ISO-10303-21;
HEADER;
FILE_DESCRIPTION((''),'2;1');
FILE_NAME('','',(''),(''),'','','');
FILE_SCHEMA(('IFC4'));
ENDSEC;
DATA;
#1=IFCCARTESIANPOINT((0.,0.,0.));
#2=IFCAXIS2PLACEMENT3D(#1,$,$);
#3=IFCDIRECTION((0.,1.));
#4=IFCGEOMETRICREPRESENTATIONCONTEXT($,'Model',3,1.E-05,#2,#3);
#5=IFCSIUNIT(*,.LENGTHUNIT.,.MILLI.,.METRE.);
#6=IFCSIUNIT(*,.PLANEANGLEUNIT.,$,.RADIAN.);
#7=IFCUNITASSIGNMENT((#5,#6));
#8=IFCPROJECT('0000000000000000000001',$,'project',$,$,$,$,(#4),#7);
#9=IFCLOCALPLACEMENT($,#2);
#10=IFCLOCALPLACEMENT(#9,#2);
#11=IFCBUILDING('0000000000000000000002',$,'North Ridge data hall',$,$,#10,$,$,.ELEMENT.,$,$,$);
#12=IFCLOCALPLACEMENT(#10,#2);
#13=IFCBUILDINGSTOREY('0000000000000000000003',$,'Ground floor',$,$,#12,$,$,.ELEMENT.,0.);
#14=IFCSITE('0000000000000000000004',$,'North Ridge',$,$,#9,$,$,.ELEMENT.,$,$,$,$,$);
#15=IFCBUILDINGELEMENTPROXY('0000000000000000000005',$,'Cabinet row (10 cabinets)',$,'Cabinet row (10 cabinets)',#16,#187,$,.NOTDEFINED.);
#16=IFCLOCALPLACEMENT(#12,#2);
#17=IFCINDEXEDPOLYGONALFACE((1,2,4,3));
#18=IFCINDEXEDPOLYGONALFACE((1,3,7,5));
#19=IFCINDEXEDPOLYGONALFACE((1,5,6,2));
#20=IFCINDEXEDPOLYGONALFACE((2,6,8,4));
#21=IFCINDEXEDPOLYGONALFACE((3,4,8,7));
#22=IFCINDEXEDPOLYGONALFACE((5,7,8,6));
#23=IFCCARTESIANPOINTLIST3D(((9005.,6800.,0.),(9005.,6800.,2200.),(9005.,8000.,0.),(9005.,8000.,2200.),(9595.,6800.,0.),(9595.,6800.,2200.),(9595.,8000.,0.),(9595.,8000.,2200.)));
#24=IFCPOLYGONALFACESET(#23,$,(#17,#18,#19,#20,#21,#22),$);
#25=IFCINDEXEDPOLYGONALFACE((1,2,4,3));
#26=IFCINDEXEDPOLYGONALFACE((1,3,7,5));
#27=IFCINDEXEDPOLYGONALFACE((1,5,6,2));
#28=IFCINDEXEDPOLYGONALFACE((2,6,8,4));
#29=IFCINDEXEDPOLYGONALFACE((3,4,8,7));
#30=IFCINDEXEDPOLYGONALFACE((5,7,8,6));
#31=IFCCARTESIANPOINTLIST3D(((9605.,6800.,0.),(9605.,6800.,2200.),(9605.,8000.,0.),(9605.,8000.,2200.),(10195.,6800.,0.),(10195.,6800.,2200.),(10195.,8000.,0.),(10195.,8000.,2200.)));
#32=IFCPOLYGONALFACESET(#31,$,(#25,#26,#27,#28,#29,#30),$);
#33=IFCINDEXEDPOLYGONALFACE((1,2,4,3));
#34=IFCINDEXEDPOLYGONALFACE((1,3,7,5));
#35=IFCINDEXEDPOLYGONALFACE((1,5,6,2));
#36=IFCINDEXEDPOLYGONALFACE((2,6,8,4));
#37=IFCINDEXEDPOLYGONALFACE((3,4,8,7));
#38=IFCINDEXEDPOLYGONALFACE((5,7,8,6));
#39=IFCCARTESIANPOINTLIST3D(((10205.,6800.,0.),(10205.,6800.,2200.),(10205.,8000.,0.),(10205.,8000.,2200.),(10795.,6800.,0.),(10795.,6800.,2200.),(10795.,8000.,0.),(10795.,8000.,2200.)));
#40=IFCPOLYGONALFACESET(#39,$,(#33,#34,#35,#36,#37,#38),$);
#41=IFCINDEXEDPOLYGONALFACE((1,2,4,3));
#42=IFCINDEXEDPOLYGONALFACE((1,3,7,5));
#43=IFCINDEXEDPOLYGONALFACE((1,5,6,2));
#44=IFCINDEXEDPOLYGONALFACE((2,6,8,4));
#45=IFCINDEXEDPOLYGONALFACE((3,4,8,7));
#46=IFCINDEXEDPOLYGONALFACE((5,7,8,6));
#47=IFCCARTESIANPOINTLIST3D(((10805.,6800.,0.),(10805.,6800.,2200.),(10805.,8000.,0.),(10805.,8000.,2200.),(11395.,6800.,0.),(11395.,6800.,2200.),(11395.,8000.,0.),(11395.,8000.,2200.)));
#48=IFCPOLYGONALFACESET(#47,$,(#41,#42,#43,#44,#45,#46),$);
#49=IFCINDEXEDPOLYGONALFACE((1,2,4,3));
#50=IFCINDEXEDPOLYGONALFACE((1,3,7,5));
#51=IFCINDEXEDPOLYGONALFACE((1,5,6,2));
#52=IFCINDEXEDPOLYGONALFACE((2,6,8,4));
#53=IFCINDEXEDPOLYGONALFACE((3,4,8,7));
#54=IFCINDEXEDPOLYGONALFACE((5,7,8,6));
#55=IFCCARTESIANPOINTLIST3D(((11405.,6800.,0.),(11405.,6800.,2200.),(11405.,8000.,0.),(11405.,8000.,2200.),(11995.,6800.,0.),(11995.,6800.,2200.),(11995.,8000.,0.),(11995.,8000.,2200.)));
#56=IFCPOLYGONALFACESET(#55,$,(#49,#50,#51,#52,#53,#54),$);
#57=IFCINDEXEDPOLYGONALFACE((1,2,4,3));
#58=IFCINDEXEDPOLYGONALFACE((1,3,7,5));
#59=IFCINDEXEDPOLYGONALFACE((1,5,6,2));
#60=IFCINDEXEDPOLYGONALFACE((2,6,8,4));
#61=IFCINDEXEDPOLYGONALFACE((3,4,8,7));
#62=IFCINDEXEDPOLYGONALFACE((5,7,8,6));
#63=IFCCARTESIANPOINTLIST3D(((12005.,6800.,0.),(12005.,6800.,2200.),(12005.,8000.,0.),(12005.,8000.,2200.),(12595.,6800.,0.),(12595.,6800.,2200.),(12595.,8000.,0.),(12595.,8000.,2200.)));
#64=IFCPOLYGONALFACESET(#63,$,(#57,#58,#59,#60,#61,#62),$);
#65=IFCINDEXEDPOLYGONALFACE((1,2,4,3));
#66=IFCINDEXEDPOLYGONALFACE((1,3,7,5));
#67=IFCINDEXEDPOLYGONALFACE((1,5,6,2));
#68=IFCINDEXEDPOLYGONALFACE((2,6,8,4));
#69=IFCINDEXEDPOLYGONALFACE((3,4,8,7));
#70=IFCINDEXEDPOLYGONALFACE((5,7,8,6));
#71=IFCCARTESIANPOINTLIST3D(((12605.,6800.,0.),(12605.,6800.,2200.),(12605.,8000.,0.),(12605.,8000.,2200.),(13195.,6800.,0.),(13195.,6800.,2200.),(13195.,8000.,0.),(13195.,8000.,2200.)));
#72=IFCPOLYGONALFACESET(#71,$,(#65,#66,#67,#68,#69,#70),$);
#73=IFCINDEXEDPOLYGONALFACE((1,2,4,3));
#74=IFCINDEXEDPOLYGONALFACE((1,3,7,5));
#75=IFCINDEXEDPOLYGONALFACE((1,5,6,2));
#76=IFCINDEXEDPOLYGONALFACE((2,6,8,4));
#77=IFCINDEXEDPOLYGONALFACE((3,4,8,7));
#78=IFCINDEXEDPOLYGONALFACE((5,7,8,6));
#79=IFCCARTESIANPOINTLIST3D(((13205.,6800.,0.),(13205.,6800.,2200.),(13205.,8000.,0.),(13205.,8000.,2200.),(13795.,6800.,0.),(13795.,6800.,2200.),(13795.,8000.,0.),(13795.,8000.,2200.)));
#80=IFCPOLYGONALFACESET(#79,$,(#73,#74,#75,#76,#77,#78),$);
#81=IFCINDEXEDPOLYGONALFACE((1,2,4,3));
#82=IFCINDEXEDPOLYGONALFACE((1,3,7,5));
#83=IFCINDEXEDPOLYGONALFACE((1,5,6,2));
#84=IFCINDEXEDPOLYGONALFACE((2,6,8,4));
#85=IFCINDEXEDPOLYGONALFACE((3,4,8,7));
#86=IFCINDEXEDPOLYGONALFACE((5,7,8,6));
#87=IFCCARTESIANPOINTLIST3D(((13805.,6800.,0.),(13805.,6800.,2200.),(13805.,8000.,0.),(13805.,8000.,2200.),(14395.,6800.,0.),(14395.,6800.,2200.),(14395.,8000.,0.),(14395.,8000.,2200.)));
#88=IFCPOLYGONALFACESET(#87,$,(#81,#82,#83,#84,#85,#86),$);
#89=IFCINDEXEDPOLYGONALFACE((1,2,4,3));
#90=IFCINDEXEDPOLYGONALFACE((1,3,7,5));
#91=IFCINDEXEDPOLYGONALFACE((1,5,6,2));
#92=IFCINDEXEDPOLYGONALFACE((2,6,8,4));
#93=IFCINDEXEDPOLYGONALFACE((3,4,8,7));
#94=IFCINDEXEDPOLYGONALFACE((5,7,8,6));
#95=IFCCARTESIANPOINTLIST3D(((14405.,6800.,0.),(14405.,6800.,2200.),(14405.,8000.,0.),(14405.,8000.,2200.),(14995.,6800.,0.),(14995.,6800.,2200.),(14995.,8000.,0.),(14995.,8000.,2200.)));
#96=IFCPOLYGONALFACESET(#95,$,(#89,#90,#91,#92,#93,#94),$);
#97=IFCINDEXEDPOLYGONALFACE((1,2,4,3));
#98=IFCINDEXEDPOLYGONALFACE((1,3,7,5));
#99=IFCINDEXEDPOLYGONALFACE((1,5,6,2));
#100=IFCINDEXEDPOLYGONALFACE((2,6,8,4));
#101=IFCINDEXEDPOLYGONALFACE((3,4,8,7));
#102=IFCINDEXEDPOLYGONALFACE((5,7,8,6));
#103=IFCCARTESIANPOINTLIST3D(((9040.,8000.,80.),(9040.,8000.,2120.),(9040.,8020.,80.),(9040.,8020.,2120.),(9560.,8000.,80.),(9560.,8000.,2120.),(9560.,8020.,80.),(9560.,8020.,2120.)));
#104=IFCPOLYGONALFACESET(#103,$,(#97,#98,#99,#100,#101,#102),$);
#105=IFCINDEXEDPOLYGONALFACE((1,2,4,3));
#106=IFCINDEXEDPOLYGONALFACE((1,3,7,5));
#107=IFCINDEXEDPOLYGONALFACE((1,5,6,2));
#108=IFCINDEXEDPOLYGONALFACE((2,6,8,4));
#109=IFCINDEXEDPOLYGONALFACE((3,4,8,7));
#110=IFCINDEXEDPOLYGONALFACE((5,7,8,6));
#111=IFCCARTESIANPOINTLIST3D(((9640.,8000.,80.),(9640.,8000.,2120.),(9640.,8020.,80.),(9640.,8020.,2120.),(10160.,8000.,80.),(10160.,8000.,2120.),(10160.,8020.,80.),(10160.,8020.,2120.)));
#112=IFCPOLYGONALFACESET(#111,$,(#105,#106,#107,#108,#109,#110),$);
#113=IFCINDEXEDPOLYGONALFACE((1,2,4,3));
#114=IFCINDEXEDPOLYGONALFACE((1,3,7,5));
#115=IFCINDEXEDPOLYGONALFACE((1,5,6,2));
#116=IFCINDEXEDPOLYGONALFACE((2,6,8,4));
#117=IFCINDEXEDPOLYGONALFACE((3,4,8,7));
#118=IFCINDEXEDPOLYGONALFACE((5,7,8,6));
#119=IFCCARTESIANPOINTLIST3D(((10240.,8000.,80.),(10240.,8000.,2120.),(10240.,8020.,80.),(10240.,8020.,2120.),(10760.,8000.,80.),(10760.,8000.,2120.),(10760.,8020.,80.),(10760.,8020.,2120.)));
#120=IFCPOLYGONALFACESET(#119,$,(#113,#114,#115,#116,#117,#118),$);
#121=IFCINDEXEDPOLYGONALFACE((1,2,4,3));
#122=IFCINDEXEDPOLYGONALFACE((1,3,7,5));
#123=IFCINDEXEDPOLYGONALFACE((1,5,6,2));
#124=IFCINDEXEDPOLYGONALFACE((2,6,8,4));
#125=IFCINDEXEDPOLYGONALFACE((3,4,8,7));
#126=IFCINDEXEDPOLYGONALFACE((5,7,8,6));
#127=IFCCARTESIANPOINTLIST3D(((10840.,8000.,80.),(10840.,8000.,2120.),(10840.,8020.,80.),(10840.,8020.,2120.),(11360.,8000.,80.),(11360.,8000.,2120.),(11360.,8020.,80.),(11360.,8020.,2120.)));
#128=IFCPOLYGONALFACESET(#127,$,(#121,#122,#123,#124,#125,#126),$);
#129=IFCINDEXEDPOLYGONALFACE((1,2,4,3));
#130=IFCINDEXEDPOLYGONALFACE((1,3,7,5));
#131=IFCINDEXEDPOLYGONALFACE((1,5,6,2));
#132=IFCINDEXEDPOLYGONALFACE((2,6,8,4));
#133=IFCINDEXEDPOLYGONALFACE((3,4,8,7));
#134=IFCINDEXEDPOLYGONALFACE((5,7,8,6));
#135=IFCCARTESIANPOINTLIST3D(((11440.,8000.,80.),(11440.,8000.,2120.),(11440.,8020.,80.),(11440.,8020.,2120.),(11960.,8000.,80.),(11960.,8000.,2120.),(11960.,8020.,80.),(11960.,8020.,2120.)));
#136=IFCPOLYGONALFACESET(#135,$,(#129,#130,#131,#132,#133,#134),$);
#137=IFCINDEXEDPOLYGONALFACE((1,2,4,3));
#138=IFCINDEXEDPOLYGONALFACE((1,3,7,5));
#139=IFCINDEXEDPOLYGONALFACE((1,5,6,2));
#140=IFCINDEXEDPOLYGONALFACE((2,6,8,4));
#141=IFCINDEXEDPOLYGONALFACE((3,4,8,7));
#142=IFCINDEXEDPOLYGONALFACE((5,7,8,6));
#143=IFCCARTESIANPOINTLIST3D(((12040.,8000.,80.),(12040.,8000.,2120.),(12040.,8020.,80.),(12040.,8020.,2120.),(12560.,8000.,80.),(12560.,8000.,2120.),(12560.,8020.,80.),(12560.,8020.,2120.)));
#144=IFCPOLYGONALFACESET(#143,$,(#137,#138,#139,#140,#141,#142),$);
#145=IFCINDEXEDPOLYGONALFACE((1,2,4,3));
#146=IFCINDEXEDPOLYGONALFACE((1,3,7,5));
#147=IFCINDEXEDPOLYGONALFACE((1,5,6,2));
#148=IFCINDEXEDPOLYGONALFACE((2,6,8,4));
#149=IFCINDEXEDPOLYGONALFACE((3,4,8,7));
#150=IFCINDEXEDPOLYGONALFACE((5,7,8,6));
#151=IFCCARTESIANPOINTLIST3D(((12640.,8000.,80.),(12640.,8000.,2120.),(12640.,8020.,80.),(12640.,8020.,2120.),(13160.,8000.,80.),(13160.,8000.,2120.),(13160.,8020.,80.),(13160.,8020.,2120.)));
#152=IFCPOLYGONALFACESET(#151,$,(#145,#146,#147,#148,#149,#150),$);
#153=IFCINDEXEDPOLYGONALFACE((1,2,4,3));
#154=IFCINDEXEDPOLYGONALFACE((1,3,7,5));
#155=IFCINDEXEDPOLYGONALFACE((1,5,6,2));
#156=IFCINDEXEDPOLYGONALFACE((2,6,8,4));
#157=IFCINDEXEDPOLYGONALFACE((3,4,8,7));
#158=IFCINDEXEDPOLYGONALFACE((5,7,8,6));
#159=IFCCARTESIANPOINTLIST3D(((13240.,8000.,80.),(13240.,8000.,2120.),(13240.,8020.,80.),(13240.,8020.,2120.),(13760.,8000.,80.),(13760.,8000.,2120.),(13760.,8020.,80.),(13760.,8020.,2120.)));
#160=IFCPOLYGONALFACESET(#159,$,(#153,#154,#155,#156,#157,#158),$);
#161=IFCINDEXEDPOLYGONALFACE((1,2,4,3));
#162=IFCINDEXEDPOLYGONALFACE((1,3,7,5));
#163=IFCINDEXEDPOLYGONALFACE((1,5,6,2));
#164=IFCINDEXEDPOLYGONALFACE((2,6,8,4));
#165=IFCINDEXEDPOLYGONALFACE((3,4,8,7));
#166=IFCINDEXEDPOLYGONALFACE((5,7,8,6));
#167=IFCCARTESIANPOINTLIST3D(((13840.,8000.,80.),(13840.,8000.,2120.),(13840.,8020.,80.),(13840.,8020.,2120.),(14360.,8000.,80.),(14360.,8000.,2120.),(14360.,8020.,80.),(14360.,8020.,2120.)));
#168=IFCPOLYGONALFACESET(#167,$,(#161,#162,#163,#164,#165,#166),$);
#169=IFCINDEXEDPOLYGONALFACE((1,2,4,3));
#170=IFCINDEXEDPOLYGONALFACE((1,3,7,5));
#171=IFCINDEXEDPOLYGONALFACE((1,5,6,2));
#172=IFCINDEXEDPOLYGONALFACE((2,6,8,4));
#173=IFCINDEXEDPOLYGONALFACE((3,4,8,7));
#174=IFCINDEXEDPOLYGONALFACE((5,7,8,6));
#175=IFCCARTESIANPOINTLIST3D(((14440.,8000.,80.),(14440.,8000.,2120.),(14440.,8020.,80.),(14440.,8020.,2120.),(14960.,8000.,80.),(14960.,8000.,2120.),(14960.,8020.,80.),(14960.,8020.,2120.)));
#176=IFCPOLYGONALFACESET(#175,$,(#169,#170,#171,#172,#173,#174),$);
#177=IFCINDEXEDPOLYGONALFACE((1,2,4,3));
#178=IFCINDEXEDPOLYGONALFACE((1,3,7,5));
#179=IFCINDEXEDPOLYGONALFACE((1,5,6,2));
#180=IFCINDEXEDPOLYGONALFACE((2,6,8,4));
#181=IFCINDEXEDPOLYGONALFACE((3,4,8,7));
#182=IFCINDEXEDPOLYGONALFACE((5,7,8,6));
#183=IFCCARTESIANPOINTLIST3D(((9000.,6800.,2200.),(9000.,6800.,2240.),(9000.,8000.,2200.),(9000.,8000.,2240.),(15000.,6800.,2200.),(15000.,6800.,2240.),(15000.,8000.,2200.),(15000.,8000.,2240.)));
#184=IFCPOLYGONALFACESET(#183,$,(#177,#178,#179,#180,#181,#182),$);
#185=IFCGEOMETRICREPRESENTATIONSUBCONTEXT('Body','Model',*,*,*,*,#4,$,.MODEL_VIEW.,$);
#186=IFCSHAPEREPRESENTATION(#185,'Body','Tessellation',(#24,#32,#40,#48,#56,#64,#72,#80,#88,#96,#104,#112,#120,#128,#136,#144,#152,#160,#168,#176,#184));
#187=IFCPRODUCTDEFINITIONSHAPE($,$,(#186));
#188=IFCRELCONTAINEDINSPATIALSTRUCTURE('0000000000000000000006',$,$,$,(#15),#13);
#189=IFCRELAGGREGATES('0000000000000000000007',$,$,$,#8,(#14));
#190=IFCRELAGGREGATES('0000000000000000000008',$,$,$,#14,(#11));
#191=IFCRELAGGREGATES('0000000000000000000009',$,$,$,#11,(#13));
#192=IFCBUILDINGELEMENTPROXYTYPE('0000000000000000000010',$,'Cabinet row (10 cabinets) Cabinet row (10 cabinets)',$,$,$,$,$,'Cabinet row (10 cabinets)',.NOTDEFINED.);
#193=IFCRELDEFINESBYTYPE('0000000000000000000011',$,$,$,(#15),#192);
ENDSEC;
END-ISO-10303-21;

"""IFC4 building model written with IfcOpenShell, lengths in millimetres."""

from ifc_helpers import new_model, si_unit, direction, frame, origin, place, context, subcontext, project, spatial, polyline, outline, extrude, source, transform, mapped, type_object, type_shapes, element, save


model = new_model("IFC4")

# Units and contexts
model_context = context("Model", 3, precision=1e-05, world=origin(), true_north=direction((0.0, 1.0)))
body_context = subcontext(model_context, "Body", "Model", "MODEL_VIEW")
ifc_project = project(units=[si_unit("LENGTHUNIT", "METRE", prefix="MILLI"), si_unit("PLANEANGLEUNIT", "RADIAN")], contexts=[model_context])

# Site, building, storey
site_placement = place(None, origin())
site = spatial("IfcSite", under=ifc_project, at=site_placement, Name="North Ridge", CompositionType="ELEMENT")
building_placement = place(site_placement, origin())
building = spatial("IfcBuilding", under=site, at=building_placement, Name="North Ridge data hall", CompositionType="ELEMENT")
storey_placement = place(building_placement, origin())
storey = spatial("IfcBuildingStorey", under=building, at=storey_placement, Name="Ground floor", CompositionType="ELEMENT", Elevation=0.0)

# Building element proxy
building_element_proxy_type_1 = type_object("IfcBuildingElementProxyType", Name="Cabinet row (10 cabinets) Cabinet row (10 cabinets)", ElementType="Cabinet row (10 cabinets)", PredefinedType="NOTDEFINED")
shared_shape_1 = source(origin(), body_context, "Body", "SweptSolid", [
    extrude(outline(polyline([(5.0, 0.0), (595.0, 0.0), (595.0, 1200.0), (5.0, 1200.0), (5.0, 0.0)])), origin(), (0.0, 0.0, 1.0), 2200.0),
    extrude(outline(polyline([(605.0, 0.0), (1195.0, 0.0), (1195.0, 1200.0), (605.0, 1200.0), (605.0, 0.0)])), origin(), (0.0, 0.0, 1.0), 2200.0),
    extrude(outline(polyline([(1205.0, 0.0), (1795.0, 0.0), (1795.0, 1200.0), (1205.0, 1200.0), (1205.0, 0.0)])), origin(), (0.0, 0.0, 1.0), 2200.0),
    extrude(outline(polyline([(1805.0, 0.0), (2395.0, 0.0), (2395.0, 1200.0), (1805.0, 1200.0), (1805.0, 0.0)])), origin(), (0.0, 0.0, 1.0), 2200.0),
    extrude(outline(polyline([(2405.0, 0.0), (2995.0, 0.0), (2995.0, 1200.0), (2405.0, 1200.0), (2405.0, 0.0)])), origin(), (0.0, 0.0, 1.0), 2200.0),
    extrude(outline(polyline([(3005.0, 0.0), (3595.0, 0.0), (3595.0, 1200.0), (3005.0, 1200.0), (3005.0, 0.0)])), origin(), (0.0, 0.0, 1.0), 2200.0),
    extrude(outline(polyline([(3605.0, 0.0), (4195.0, 0.0), (4195.0, 1200.0), (3605.0, 1200.0), (3605.0, 0.0)])), origin(), (0.0, 0.0, 1.0), 2200.0),
    extrude(outline(polyline([(4205.0, 0.0), (4795.0, 0.0), (4795.0, 1200.0), (4205.0, 1200.0), (4205.0, 0.0)])), origin(), (0.0, 0.0, 1.0), 2200.0),
    extrude(outline(polyline([(4805.0, 0.0), (5395.0, 0.0), (5395.0, 1200.0), (4805.0, 1200.0), (4805.0, 0.0)])), origin(), (0.0, 0.0, 1.0), 2200.0),
    extrude(outline(polyline([(5405.0, 0.0), (5995.0, 0.0), (5995.0, 1200.0), (5405.0, 1200.0), (5405.0, 0.0)])), origin(), (0.0, 0.0, 1.0), 2200.0),
    extrude(outline(polyline([(40.0, 1200.0), (560.0, 1200.0), (560.0, 1220.0), (40.0, 1220.0), (40.0, 1200.0)])), frame((0.0, 0.0, 80.0)), (0.0, 0.0, 1.0), 2040.0),
    extrude(outline(polyline([(640.0, 1200.0), (1160.0, 1200.0), (1160.0, 1220.0), (640.0, 1220.0), (640.0, 1200.0)])), frame((0.0, 0.0, 80.0)), (0.0, 0.0, 1.0), 2040.0),
    extrude(outline(polyline([(1240.0, 1200.0), (1760.0, 1200.0), (1760.0, 1220.0), (1240.0, 1220.0), (1240.0, 1200.0)])), frame((0.0, 0.0, 80.0)), (0.0, 0.0, 1.0), 2040.0),
    extrude(outline(polyline([(1840.0, 1200.0), (2360.0, 1200.0), (2360.0, 1220.0), (1840.0, 1220.0), (1840.0, 1200.0)])), frame((0.0, 0.0, 80.0)), (0.0, 0.0, 1.0), 2040.0),
    extrude(outline(polyline([(2440.0, 1200.0), (2960.0, 1200.0), (2960.0, 1220.0), (2440.0, 1220.0), (2440.0, 1200.0)])), frame((0.0, 0.0, 80.0)), (0.0, 0.0, 1.0), 2040.0),
    extrude(outline(polyline([(3040.0, 1200.0), (3560.0, 1200.0), (3560.0, 1220.0), (3040.0, 1220.0), (3040.0, 1200.0)])), frame((0.0, 0.0, 80.0)), (0.0, 0.0, 1.0), 2040.0),
    extrude(outline(polyline([(3640.0, 1200.0), (4160.0, 1200.0), (4160.0, 1220.0), (3640.0, 1220.0), (3640.0, 1200.0)])), frame((0.0, 0.0, 80.0)), (0.0, 0.0, 1.0), 2040.0),
    extrude(outline(polyline([(4240.0, 1200.0), (4760.0, 1200.0), (4760.0, 1220.0), (4240.0, 1220.0), (4240.0, 1200.0)])), frame((0.0, 0.0, 80.0)), (0.0, 0.0, 1.0), 2040.0),
    extrude(outline(polyline([(4840.0, 1200.0), (5360.0, 1200.0), (5360.0, 1220.0), (4840.0, 1220.0), (4840.0, 1200.0)])), frame((0.0, 0.0, 80.0)), (0.0, 0.0, 1.0), 2040.0),
    extrude(outline(polyline([(5440.0, 1200.0), (5960.0, 1200.0), (5960.0, 1220.0), (5440.0, 1220.0), (5440.0, 1200.0)])), frame((0.0, 0.0, 80.0)), (0.0, 0.0, 1.0), 2040.0),
    extrude(outline(polyline([(0.0, 0.0), (6000.0, 0.0), (6000.0, 1200.0), (0.0, 1200.0), (0.0, 0.0)])), frame((0.0, 0.0, 2200.0)), (0.0, 0.0, 1.0), 40.0),
])
type_shapes(building_element_proxy_type_1, [shared_shape_1])
for number, where, z_axis, x_axis, name in (
    (1, (9000.0, 6800.0, 0.0), (0.0, 0.0, 1.0), (1.0, 0.0, 0.0), "Cabinet row (10 cabinets)"),
):
    element("IfcBuildingElementProxy", number, at=place(storey_placement, frame(where, z_axis=z_axis, x_axis=x_axis)), inside=storey, type_object=building_element_proxy_type_1, Name=name, ObjectType="Cabinet row (10 cabinets)", PredefinedType="NOTDEFINED", context=body_context, shape_type="MappedRepresentation", body=[
        mapped(shared_shape_1, transform((0.0, 0.0, 0.0))),
    ])

save(model, "model.ifc")
